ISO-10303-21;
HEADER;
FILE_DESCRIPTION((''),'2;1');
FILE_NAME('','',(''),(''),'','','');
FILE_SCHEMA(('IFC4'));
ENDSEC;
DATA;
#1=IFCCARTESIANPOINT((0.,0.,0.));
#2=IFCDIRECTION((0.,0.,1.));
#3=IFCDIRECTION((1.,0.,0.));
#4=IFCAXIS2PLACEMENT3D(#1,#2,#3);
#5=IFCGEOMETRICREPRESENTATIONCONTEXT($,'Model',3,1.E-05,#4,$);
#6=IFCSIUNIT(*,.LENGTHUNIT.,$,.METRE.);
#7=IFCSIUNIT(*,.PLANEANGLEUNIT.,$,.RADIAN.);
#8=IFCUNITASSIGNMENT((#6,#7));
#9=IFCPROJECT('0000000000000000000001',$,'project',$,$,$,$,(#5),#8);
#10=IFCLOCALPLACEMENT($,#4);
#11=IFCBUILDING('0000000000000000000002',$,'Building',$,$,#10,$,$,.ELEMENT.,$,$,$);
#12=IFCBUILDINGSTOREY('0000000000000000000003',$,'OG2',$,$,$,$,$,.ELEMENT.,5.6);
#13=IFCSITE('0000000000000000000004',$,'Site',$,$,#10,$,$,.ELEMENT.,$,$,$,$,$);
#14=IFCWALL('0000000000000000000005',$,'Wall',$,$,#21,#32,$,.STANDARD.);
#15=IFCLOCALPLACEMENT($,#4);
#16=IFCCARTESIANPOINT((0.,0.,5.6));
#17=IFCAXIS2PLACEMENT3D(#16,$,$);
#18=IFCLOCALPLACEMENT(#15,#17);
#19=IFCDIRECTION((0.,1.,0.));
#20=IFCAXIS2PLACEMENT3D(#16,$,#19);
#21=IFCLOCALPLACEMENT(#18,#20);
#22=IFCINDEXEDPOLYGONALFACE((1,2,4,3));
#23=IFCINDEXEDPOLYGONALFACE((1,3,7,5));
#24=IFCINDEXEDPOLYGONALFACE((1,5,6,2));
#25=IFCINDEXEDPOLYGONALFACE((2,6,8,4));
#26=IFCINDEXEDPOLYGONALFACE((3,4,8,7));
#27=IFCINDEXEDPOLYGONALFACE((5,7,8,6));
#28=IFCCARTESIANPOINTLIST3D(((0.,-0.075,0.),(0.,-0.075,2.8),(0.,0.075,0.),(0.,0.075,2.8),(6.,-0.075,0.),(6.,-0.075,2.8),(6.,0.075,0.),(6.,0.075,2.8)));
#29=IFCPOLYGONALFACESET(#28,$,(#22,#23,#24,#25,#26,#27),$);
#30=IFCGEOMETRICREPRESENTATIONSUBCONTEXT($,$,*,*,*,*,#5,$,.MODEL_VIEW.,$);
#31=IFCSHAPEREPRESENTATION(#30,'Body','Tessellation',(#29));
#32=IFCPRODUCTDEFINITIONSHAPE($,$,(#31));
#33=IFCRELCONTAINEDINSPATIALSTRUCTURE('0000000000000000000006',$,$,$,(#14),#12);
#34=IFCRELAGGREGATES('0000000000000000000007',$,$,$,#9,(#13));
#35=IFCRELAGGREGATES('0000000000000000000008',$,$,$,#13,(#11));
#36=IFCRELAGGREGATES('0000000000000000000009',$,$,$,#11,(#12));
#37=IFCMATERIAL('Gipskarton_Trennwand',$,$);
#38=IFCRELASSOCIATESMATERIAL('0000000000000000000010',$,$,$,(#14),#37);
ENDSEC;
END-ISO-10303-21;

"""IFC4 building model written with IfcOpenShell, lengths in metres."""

from ifc_helpers import new_model, si_unit, frame, frame_2d, origin, origin_with_axes, place, context, subcontext, project, spatial, rectangle, extrude, material, element, save


model = new_model("IFC4")

# Units and contexts
model_context = context("Model", 3, precision=1e-05, world=origin_with_axes())
sub_context = subcontext(model_context, None, None, "MODEL_VIEW")
ifc_project = project(units=[si_unit("LENGTHUNIT", "METRE"), si_unit("PLANEANGLEUNIT", "RADIAN")], contexts=[model_context])

# Site, building, storey
placement_1 = place(None, origin_with_axes())
site = spatial("IfcSite", under=ifc_project, at=placement_1, Name="Site", CompositionType="ELEMENT")
building = spatial("IfcBuilding", under=site, at=placement_1, Name="Building", CompositionType="ELEMENT")
storey = spatial("IfcBuildingStorey", under=building, Name="OG2", CompositionType="ELEMENT", Elevation=5.6)

# Wall
ifc_material = material(Name="Gipskarton_Trennwand")
placement_2 = place(None, origin_with_axes())
placement_3 = place(placement_2, frame((0.0, 0.0, 5.6)))
wall_placement = place(placement_3, frame((0.0, 0.0, 5.6), x_axis=(0.0, 1.0, 0.0)))
element("IfcWall", 1, at=wall_placement, inside=storey, material=ifc_material, Name="Wall", PredefinedType="STANDARD", context=sub_context, shape_type="SweptSolid", body=[
    extrude(rectangle(XDim=6.0, YDim=0.15, at=frame_2d((3.0, 0.0))), origin(), (0.0, 0.0, 1.0), 2.8),
])

save(model, "model.ifc")
